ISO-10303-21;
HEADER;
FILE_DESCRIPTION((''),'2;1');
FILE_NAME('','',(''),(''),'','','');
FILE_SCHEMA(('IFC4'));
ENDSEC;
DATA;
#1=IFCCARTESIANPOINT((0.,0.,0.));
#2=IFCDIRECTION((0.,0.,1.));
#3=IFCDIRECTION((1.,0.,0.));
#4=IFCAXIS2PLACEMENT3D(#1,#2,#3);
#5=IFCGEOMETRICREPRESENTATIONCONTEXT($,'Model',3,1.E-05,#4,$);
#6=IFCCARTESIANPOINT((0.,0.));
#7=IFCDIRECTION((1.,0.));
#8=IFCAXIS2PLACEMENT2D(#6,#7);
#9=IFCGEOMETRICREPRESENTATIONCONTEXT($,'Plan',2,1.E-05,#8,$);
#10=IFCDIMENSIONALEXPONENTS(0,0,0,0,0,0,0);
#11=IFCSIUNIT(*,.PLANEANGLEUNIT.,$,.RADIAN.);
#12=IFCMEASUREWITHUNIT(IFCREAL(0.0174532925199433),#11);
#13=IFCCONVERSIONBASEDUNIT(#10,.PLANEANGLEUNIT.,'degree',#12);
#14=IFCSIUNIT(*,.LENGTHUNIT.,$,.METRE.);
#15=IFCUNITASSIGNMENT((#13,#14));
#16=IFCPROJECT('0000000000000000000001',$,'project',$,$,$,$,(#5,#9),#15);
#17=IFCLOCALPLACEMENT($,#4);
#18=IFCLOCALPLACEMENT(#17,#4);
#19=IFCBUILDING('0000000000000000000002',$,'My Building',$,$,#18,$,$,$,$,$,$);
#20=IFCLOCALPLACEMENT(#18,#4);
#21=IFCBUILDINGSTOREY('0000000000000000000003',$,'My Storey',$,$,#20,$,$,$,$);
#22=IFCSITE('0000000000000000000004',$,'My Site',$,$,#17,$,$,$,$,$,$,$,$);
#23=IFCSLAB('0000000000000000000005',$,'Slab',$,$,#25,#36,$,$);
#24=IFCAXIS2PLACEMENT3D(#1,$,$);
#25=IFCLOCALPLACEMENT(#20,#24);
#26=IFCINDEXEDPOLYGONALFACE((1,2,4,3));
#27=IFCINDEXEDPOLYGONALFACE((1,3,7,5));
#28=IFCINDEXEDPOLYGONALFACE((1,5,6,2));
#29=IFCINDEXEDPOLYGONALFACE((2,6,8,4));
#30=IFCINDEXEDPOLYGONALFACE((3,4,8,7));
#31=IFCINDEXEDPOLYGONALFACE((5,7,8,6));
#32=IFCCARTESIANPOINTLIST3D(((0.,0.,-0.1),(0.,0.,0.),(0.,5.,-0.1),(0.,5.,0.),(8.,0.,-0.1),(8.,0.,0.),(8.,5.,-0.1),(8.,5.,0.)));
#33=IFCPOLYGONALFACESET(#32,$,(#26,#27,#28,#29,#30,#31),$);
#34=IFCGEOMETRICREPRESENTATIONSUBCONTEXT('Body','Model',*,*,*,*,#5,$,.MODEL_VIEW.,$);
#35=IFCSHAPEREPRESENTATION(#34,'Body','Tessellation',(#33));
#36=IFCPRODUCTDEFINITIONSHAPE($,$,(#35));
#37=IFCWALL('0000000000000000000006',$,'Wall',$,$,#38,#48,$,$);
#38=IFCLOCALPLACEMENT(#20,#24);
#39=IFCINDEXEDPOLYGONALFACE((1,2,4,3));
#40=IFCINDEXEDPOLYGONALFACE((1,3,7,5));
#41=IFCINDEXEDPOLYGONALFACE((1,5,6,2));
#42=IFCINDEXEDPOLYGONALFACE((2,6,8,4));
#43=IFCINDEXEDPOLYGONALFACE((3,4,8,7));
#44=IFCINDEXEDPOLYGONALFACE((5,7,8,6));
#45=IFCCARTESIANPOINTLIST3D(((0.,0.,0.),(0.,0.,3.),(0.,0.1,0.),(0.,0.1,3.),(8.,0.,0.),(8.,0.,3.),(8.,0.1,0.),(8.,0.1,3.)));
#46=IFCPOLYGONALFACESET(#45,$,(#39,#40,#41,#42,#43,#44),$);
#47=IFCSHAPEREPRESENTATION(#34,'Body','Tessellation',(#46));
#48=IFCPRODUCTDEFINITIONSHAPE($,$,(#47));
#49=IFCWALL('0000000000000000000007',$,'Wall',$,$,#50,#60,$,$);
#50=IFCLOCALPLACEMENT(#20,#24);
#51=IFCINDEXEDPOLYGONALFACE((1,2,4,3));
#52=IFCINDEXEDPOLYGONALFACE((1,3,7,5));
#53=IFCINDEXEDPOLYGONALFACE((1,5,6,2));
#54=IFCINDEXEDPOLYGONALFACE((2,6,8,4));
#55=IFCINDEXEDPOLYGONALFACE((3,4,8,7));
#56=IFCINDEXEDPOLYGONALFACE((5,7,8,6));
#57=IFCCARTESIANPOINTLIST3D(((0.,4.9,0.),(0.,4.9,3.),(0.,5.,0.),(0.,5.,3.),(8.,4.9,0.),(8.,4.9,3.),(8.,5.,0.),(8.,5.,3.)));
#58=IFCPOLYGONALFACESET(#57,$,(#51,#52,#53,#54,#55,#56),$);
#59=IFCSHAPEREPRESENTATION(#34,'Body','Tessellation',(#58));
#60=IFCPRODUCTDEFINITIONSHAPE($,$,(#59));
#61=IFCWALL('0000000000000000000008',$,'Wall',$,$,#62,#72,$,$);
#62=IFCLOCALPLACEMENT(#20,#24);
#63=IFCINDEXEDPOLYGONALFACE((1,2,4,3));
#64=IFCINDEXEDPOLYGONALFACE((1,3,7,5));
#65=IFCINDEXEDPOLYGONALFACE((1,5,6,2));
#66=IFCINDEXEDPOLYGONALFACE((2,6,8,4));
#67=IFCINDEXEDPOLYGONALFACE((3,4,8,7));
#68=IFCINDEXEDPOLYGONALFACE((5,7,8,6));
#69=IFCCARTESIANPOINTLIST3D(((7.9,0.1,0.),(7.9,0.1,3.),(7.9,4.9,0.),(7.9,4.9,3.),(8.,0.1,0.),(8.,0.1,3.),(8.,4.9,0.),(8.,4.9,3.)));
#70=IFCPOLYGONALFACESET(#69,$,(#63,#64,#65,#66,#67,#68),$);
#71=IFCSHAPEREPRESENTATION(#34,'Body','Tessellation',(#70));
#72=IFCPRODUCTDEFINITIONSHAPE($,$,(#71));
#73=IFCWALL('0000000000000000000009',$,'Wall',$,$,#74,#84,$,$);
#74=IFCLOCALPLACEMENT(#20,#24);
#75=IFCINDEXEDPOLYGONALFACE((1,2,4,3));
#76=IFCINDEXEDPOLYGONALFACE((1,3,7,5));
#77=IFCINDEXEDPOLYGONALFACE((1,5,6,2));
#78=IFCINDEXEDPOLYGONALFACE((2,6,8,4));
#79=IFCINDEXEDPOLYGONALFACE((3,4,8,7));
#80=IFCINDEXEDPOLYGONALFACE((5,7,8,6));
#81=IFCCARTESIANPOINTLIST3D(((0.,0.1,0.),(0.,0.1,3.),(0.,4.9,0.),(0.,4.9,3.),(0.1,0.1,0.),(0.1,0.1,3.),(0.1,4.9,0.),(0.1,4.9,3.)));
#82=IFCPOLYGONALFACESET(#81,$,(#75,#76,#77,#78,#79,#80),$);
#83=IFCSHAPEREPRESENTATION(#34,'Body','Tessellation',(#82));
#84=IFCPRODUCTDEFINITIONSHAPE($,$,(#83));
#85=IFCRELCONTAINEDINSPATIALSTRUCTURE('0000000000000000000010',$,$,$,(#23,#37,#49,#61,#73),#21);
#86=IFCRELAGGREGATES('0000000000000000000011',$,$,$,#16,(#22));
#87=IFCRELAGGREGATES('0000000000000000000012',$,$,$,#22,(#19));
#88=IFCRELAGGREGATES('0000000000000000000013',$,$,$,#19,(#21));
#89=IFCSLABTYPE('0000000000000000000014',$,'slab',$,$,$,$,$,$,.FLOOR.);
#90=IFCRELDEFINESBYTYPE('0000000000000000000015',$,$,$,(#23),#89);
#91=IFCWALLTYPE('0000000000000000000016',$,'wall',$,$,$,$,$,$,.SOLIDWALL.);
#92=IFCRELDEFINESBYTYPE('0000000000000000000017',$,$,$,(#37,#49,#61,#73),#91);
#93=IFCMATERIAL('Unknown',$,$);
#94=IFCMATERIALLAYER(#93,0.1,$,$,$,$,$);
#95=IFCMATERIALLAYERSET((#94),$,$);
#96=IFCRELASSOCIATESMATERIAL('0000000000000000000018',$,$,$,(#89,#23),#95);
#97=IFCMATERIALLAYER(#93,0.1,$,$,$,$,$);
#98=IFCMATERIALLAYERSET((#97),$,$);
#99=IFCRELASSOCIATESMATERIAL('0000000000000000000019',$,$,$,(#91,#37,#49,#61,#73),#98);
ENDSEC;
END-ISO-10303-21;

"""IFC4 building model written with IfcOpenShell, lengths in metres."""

from ifc_helpers import new_model, entity, si_unit, converted_unit, frame, origin_with_axes, origin_2d_with_axis, place, context, subcontext, project, spatial, line, indexed_curve, outline, extrude, material, layer, layer_set, layer_usage, type_object, element, save


model = new_model("IFC4")

# Units and contexts
model_context = context("Model", 3, precision=1e-05, world=origin_with_axes())
plan_context = context("Plan", 2, precision=1e-05, world=origin_2d_with_axis())
body_context = subcontext(model_context, "Body", "Model", "MODEL_VIEW")
ifc_project = project(units=[converted_unit("PLANEANGLEUNIT", "degree", entity("IfcReal", 0.0174532925199433), si_unit("PLANEANGLEUNIT", "RADIAN"), dimensions=[0, 0, 0, 0, 0, 0, 0]), si_unit("LENGTHUNIT", "METRE")], contexts=[model_context, plan_context])

# Site, building, storey
site_placement = place(None, origin_with_axes())
site = spatial("IfcSite", under=ifc_project, at=site_placement, Name="My Site")
building_placement = place(site_placement, origin_with_axes())
building = spatial("IfcBuilding", under=site, at=building_placement, Name="My Building")
storey_placement = place(building_placement, origin_with_axes())
storey = spatial("IfcBuildingStorey", under=building, at=storey_placement, Name="My Storey")

# Slab
ifc_material = material(Name="Unknown")
ifc_layer_1 = layer(ifc_material, 0.1)
ifc_layer_set_1 = layer_set([ifc_layer_1])
ifc_layer_usage_1 = layer_usage(ifc_layer_set_1, "AXIS3", "POSITIVE", 0.0)
slab_type = type_object("IfcSlabType", Name="slab", PredefinedType="FLOOR", material=ifc_layer_set_1)
slab_placement = place(storey_placement, frame((0.0, 0.0, -0.1), z_axis=(0.0, 0.0, 1.0), x_axis=(1.0, 0.0, 0.0)))
element("IfcSlab", 1, at=slab_placement, inside=storey, type_object=slab_type, material=ifc_layer_usage_1, Name="Slab", context=body_context, shape_type="SweptSolid", body=[
    extrude(outline(indexed_curve([(0.0, 0.0), (8.0, 0.0), (8.0, 5.0), (0.0, 5.0)], segments=[line(3, 2), line(2, 1), line(1, 4), line(4, 3)], self_intersect=False)), None, (0.0, 0.0, 1.0), 0.1),
])

# Walls
ifc_layer_2 = layer(ifc_material, 0.1)
ifc_layer_set_2 = layer_set([ifc_layer_2])
ifc_layer_usage_2 = layer_usage(ifc_layer_set_2, "AXIS2", "POSITIVE", 0.0)
wall_type = type_object("IfcWallType", Name="wall", PredefinedType="SOLIDWALL", material=ifc_layer_set_2)
wall_1_placement = place(storey_placement, origin_with_axes())
element("IfcWall", 2, at=wall_1_placement, inside=storey, type_object=wall_type, material=ifc_layer_usage_2, Name="Wall", context=body_context, shape_type="SweptSolid", body=[
    extrude(outline(indexed_curve([(0.0, 0.0), (0.0, 0.1), (8.0, 0.1), (8.0, 0.0), (0.0, 0.0)], self_intersect=False)), origin_with_axes(), (0.0, 0.0, 1.0), 3.0),
])
ifc_layer_usage_3 = layer_usage(ifc_layer_set_2, "AXIS2", "POSITIVE", 0.0)
wall_2_placement = place(storey_placement, frame((0.0, 4.9, 0.0), z_axis=(0.0, 0.0, 1.0), x_axis=(1.0, 0.0, 0.0)))
element("IfcWall", 3, at=wall_2_placement, inside=storey, type_object=wall_type, material=ifc_layer_usage_3, Name="Wall", context=body_context, shape_type="SweptSolid", body=[
    extrude(outline(indexed_curve([(0.0, 0.0), (0.0, 0.1), (8.0, 0.1), (8.0, 0.0), (0.0, 0.0)], self_intersect=False)), origin_with_axes(), (0.0, 0.0, 1.0), 3.0),
])
ifc_layer_usage_4 = layer_usage(ifc_layer_set_2, "AXIS2", "POSITIVE", 0.0)
wall_3_placement = place(storey_placement, frame((8.0, 0.1, 0.0), z_axis=(0.0, 0.0, 1.0), x_axis=(0.0, 1.0, 0.0)))
element("IfcWall", 4, at=wall_3_placement, inside=storey, type_object=wall_type, material=ifc_layer_usage_4, Name="Wall", context=body_context, shape_type="SweptSolid", body=[
    extrude(outline(indexed_curve([(0.0, 0.0), (0.0, 0.1), (4.8, 0.1), (4.8, 0.0), (0.0, 0.0)], self_intersect=False)), origin_with_axes(), (0.0, 0.0, 1.0), 3.0),
])
ifc_layer_usage_5 = layer_usage(ifc_layer_set_2, "AXIS2", "POSITIVE", 0.0)
wall_4_placement = place(storey_placement, frame((0.1, 0.1, 0.0), z_axis=(0.0, 0.0, 1.0), x_axis=(0.0, 1.0, 0.0)))
element("IfcWall", 5, at=wall_4_placement, inside=storey, type_object=wall_type, material=ifc_layer_usage_5, Name="Wall", context=body_context, shape_type="SweptSolid", body=[
    extrude(outline(indexed_curve([(0.0, 0.0), (0.0, 0.1), (4.8, 0.1), (4.8, 0.0), (0.0, 0.0)], self_intersect=False)), origin_with_axes(), (0.0, 0.0, 1.0), 3.0),
])

save(model, "model.ifc")
